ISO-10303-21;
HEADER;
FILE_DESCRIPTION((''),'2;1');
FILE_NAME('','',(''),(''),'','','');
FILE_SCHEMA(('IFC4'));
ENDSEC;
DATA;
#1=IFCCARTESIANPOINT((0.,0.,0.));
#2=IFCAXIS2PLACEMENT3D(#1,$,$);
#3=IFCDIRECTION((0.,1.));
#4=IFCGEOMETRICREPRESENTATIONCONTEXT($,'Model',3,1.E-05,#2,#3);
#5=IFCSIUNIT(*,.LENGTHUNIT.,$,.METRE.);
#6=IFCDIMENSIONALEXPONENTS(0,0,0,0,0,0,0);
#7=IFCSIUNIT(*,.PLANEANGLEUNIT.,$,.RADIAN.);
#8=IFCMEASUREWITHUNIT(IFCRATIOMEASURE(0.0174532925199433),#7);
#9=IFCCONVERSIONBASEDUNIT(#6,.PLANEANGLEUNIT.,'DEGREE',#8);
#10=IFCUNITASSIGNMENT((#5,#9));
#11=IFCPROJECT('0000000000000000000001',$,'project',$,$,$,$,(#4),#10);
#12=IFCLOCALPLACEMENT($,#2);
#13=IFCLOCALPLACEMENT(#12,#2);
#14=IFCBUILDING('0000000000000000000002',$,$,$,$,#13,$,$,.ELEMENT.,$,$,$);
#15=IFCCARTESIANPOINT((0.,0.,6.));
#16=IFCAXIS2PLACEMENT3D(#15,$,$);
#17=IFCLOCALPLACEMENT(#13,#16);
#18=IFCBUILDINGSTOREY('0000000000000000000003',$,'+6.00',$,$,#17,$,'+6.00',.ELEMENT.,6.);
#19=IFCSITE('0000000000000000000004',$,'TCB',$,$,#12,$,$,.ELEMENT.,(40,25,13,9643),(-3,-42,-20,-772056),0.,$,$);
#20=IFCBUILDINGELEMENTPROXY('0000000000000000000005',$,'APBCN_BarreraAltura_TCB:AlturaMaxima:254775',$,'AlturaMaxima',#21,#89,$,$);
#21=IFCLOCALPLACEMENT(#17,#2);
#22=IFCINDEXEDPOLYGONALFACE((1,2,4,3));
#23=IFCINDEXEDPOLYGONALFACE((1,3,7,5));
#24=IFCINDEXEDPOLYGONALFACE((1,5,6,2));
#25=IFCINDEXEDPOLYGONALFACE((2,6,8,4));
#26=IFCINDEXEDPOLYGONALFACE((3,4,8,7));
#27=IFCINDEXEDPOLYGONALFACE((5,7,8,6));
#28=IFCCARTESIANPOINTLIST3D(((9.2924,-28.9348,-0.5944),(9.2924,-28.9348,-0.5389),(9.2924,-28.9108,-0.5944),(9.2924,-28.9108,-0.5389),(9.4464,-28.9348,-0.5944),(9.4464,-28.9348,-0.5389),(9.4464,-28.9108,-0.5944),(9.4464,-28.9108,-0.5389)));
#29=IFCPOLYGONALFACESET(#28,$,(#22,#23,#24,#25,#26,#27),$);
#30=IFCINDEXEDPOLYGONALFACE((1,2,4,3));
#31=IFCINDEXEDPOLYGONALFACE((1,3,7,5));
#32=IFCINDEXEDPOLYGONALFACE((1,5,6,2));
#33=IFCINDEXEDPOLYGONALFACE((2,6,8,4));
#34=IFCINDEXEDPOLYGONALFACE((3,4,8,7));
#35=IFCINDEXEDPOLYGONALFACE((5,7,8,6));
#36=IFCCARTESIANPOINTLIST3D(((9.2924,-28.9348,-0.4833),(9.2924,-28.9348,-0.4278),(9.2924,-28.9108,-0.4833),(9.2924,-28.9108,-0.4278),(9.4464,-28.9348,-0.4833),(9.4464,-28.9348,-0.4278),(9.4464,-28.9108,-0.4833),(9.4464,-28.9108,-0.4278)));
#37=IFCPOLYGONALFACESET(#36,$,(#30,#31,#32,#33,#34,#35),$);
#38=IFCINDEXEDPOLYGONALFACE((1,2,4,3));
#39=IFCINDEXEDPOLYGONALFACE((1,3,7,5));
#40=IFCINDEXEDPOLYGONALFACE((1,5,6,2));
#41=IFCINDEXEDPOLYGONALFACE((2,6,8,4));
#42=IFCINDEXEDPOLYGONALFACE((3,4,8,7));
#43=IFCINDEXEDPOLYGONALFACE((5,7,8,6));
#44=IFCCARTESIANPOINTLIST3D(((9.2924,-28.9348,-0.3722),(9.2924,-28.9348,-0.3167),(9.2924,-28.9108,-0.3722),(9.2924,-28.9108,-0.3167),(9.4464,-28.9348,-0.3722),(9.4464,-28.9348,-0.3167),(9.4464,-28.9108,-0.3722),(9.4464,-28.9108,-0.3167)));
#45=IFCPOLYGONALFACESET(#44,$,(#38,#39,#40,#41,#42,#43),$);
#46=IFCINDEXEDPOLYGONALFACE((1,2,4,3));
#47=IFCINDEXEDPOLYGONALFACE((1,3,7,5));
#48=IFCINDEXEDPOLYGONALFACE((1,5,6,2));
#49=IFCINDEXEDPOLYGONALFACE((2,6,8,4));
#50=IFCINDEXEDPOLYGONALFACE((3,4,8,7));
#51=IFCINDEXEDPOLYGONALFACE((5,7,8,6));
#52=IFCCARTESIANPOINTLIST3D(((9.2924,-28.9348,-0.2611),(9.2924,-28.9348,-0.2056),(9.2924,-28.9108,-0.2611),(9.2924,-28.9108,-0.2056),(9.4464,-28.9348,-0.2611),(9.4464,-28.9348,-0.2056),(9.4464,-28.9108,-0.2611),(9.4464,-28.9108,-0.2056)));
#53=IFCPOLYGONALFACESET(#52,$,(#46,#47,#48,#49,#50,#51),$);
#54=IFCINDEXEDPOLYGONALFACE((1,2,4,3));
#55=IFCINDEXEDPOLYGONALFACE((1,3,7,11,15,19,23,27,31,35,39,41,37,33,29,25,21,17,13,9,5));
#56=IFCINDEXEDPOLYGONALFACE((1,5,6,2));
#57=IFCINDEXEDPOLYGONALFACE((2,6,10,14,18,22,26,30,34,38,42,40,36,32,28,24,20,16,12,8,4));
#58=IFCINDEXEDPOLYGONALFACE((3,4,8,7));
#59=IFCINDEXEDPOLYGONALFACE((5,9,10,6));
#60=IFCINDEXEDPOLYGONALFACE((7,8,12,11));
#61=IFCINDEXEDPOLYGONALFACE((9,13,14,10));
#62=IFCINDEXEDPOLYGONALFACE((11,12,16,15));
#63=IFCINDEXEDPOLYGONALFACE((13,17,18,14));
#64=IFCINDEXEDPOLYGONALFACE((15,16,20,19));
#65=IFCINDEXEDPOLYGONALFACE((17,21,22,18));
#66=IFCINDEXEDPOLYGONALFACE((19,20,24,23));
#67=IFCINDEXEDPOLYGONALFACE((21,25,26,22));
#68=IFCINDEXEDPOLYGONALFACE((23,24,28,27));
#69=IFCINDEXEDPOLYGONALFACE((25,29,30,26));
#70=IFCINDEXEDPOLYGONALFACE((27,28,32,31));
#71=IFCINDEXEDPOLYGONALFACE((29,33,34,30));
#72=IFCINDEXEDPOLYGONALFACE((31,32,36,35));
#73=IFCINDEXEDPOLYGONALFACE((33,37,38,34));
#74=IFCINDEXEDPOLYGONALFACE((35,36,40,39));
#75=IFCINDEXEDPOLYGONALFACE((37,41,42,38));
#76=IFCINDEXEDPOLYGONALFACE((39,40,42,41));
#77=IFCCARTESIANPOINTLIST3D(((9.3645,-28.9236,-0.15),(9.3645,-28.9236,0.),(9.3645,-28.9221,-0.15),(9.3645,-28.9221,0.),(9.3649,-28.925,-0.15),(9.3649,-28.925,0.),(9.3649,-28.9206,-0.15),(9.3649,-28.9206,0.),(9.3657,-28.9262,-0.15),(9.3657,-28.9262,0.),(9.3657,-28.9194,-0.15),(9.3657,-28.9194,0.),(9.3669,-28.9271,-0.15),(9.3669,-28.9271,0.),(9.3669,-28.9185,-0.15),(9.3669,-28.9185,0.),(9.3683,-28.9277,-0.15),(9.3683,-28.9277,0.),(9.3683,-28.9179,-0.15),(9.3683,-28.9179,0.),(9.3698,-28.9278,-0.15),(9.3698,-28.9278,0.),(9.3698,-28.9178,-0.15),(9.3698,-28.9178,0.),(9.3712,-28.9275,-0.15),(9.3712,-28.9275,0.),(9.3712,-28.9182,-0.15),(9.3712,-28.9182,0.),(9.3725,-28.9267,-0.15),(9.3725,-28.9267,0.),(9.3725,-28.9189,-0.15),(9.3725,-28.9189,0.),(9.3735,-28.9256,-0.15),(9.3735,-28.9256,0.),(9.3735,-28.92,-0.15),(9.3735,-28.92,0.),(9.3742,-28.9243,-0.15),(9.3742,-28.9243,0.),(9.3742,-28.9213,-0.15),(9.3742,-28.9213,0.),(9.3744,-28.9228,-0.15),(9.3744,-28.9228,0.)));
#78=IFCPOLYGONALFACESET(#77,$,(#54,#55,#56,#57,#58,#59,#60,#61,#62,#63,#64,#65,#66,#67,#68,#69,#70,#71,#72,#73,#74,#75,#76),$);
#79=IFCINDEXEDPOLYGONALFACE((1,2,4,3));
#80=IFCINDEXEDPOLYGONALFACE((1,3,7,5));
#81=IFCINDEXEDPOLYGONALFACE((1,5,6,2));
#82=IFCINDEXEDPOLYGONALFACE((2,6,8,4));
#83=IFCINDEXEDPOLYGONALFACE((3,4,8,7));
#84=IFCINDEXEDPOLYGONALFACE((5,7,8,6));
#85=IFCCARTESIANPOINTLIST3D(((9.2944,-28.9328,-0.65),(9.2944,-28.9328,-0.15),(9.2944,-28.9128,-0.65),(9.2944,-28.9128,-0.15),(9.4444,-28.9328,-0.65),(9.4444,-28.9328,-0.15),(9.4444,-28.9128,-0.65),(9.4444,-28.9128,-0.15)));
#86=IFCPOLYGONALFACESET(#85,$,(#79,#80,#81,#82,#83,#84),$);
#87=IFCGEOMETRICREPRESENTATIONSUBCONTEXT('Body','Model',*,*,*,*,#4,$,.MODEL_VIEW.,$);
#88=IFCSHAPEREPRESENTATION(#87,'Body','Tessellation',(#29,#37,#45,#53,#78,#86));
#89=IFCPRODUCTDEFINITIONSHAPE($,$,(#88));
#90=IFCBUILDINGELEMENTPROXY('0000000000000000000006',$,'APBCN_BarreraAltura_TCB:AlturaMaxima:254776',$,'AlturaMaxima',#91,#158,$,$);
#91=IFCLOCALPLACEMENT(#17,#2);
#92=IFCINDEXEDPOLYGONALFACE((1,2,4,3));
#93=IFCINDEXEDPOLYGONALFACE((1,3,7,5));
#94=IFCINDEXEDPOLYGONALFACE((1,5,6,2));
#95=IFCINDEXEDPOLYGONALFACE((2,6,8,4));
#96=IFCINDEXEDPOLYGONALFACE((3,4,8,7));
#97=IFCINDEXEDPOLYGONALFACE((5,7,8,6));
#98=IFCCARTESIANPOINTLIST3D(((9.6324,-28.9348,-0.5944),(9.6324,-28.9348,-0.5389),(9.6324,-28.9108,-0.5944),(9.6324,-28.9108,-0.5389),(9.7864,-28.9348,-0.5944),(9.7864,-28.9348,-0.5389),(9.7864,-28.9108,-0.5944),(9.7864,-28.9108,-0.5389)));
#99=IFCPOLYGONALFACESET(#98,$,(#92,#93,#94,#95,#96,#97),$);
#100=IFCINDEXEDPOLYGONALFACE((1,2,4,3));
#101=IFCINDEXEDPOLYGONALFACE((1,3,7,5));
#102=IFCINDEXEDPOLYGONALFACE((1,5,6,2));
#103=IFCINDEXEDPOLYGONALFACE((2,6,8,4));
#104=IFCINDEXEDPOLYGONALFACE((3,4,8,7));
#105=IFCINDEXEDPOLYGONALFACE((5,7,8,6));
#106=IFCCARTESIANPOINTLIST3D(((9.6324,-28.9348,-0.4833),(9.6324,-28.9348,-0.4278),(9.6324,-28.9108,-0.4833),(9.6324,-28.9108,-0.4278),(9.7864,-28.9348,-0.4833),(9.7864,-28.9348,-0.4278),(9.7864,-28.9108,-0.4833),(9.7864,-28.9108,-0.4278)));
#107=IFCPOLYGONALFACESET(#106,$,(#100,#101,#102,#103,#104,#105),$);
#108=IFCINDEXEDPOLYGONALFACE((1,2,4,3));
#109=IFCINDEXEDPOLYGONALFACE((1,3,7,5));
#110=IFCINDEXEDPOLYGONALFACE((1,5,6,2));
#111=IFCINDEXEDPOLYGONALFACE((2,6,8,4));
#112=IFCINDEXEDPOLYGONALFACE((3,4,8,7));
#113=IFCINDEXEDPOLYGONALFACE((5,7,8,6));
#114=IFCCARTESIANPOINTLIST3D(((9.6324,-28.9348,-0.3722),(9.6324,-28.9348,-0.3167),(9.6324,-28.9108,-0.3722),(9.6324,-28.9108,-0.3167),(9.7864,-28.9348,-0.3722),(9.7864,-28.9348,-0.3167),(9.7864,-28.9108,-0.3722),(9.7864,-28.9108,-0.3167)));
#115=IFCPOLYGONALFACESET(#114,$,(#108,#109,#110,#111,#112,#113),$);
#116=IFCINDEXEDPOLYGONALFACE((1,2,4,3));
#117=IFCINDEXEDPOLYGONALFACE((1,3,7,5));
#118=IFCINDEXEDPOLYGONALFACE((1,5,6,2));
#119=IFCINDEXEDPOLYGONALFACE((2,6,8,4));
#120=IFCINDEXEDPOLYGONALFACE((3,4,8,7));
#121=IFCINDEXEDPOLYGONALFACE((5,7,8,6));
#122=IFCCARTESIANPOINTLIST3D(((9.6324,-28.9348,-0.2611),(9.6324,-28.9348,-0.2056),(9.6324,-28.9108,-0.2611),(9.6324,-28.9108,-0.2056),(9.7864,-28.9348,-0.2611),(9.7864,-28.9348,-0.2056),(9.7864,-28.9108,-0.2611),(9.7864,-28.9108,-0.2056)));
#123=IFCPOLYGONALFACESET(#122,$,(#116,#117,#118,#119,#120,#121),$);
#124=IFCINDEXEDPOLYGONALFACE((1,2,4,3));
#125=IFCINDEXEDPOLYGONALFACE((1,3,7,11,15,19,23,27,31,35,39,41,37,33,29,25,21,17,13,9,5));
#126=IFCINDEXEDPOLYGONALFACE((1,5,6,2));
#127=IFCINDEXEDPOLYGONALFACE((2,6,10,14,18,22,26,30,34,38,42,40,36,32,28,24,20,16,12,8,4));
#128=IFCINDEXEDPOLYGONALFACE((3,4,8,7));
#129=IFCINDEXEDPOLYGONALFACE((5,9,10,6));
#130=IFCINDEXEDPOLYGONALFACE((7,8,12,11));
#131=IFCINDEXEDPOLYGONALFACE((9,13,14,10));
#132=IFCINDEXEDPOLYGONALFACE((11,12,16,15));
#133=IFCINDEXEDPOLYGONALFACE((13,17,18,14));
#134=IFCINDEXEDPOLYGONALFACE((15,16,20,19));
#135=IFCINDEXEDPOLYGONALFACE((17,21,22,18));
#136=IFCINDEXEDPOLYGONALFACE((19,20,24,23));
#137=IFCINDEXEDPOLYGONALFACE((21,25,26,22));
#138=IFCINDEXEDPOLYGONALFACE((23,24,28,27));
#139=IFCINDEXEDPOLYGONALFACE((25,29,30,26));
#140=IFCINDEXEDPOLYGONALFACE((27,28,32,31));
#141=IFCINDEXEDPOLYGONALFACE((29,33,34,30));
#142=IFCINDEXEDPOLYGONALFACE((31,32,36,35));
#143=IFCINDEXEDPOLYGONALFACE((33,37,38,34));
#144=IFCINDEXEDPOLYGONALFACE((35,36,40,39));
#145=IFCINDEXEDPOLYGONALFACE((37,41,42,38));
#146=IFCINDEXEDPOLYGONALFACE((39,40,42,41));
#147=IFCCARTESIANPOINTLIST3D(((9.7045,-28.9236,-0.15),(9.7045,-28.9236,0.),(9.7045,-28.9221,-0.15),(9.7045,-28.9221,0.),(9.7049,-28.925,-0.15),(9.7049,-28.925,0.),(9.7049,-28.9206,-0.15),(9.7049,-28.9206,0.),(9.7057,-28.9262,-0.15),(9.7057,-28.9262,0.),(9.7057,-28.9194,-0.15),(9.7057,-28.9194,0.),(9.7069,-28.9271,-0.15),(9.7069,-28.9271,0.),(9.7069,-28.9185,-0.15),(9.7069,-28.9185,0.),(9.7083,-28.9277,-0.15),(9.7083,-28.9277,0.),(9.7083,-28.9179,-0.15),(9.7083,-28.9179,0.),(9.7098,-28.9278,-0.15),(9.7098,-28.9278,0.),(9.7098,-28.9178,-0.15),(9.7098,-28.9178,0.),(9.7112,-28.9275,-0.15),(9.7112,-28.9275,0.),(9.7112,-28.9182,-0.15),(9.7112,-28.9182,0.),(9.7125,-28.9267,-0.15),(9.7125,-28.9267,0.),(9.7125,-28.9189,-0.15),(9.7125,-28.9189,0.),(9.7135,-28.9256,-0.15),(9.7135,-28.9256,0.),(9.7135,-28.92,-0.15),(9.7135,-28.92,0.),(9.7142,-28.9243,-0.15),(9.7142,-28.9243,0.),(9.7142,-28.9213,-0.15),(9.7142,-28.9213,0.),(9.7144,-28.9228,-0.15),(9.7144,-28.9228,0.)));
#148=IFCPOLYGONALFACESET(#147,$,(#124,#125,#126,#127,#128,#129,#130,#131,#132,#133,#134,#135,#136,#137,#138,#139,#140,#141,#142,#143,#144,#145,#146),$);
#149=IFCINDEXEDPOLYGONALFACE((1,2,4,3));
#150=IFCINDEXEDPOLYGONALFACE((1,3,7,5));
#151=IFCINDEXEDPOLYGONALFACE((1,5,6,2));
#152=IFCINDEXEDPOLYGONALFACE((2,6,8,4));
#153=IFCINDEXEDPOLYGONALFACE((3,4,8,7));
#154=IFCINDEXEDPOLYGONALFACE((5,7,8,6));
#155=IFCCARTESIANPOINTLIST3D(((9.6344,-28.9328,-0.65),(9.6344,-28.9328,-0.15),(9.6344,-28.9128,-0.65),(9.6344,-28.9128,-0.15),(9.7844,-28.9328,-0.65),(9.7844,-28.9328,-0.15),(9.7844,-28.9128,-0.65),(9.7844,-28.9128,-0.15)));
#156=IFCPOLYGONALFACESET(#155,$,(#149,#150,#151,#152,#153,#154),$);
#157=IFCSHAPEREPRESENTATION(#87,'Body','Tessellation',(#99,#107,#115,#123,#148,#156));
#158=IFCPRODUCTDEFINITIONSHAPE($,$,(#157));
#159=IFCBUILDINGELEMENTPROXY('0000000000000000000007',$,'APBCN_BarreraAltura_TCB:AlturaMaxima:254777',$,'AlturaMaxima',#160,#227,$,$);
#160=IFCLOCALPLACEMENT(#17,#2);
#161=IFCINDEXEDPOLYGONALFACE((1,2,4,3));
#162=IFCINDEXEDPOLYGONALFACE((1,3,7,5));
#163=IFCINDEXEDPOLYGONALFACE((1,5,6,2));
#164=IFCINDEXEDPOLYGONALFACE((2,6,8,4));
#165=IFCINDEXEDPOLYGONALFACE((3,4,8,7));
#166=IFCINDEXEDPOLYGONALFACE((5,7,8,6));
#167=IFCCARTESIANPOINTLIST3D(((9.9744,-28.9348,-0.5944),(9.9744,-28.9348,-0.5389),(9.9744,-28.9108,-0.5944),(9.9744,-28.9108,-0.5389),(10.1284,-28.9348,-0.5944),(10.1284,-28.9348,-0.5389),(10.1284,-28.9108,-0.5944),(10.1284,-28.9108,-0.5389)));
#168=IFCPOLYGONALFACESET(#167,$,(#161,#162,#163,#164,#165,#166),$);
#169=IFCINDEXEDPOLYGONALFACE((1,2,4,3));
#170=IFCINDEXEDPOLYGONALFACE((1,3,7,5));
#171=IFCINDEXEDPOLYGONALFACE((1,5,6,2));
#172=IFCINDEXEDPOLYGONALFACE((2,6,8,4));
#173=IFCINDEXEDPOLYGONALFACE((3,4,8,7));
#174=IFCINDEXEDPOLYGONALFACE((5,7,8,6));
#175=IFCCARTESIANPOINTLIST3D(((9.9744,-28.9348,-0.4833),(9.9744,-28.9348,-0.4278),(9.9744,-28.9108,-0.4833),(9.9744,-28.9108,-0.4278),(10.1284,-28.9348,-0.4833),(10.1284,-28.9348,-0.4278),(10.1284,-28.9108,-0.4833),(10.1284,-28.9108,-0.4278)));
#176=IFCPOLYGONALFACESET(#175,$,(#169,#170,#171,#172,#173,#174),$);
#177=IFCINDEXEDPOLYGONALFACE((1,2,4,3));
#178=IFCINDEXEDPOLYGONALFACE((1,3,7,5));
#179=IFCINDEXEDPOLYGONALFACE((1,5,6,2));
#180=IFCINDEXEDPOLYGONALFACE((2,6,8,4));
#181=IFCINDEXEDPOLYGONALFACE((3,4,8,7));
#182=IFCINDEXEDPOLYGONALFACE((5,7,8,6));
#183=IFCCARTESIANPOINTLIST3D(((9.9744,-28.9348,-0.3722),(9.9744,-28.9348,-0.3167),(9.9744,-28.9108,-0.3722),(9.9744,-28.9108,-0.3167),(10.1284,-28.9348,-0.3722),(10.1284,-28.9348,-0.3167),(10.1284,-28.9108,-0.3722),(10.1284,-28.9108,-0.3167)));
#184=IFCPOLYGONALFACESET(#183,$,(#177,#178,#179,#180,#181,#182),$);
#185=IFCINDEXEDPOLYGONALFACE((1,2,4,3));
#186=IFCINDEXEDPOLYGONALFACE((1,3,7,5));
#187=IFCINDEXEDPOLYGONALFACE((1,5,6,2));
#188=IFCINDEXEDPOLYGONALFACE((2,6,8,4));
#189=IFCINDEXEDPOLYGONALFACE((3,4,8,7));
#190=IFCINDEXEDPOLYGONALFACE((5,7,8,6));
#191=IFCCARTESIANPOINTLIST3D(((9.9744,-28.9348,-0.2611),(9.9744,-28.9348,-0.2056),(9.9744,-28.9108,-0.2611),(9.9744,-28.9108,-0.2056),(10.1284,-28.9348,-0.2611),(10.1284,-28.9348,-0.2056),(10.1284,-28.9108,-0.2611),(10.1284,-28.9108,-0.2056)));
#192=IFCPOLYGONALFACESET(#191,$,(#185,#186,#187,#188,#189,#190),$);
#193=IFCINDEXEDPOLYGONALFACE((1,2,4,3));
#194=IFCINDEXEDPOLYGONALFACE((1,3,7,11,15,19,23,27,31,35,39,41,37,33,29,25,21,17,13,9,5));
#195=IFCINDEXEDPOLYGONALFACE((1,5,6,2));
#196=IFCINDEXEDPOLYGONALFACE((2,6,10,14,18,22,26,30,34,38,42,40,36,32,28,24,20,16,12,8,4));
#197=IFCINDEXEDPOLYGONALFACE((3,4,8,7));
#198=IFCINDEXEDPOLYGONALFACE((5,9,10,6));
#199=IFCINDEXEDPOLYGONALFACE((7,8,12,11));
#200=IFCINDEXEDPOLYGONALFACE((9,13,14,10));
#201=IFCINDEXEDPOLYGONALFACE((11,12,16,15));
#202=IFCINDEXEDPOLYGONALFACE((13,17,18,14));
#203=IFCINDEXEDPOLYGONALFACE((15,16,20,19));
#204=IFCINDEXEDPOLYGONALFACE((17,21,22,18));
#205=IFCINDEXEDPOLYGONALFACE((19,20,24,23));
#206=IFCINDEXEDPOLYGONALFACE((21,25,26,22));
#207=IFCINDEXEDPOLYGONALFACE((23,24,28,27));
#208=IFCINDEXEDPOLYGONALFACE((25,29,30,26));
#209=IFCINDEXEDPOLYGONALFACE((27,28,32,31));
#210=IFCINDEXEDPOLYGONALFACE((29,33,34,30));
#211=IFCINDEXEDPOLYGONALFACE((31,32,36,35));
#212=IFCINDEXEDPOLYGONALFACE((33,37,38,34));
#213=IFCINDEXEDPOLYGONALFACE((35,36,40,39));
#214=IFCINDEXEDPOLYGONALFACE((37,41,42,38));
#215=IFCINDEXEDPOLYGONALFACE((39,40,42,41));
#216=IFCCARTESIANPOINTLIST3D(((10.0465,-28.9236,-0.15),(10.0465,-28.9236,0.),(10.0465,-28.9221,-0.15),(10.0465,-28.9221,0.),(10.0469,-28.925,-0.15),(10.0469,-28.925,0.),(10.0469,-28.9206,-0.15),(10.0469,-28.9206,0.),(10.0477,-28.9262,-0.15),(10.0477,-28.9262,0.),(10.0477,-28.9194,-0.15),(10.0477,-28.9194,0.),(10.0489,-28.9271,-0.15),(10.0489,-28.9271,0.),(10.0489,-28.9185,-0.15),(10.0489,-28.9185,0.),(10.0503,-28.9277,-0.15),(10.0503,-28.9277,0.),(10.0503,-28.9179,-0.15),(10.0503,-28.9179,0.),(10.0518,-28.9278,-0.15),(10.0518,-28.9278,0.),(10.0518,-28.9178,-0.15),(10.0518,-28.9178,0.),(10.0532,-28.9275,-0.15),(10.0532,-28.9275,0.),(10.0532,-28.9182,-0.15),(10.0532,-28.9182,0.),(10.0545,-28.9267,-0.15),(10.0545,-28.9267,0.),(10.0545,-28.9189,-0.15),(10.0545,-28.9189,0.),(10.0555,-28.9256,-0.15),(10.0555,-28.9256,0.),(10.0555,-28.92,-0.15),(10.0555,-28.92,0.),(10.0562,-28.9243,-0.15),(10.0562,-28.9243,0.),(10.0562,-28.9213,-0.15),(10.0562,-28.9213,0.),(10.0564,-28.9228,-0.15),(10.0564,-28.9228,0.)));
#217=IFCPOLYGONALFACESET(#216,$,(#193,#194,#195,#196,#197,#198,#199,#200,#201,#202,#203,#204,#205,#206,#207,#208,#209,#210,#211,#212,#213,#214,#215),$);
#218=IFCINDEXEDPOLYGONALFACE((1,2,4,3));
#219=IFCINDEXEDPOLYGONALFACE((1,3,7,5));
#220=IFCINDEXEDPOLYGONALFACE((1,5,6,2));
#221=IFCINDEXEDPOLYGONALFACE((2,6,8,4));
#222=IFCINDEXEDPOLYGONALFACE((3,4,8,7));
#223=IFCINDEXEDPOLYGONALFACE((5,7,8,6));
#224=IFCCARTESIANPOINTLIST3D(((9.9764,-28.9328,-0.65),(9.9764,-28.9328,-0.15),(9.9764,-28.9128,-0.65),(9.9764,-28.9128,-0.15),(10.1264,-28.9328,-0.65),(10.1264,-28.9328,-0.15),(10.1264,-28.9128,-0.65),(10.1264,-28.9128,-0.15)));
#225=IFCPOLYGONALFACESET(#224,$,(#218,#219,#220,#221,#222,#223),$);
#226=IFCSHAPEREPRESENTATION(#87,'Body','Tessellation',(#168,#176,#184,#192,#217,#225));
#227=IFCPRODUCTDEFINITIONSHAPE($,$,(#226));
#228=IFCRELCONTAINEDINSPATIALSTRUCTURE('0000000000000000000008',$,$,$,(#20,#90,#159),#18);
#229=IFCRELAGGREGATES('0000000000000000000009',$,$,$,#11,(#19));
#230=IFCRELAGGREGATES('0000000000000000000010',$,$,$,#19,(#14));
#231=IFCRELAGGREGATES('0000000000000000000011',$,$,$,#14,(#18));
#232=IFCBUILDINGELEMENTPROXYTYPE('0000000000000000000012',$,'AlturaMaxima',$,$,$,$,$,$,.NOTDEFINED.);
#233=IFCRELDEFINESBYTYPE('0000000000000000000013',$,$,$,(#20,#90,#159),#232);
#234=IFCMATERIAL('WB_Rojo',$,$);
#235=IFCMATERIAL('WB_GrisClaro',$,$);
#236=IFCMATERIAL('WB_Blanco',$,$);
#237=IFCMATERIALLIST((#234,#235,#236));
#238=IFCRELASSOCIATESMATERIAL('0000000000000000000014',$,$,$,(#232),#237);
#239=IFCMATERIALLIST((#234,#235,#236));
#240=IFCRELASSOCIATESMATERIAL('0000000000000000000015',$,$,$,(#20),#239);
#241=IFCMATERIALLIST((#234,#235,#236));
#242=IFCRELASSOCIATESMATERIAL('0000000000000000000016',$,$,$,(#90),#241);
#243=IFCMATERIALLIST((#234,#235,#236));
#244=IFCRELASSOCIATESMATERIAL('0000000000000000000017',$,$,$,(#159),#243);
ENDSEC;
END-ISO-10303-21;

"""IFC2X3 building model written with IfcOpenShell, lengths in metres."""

from ifc_helpers import new_model, entity, si_unit, converted_unit, direction, frame, frame_2d, origin, origin_2d_with_axis, place, context, subcontext, project, spatial, rectangle, circle, extrude, source, transform, mapped, material, material_list, type_object, type_shapes, element, save


model = new_model("IFC2X3")

# Units and contexts
model_context = context("Model", 3, precision=1e-05, world=origin(), true_north=direction((0.0, 1.0)))
body_context = subcontext(model_context, "Body", "Model", "MODEL_VIEW")
ifc_project = project(units=[si_unit("LENGTHUNIT", "METRE"), converted_unit("PLANEANGLEUNIT", "DEGREE", entity("IfcRatioMeasure", 0.0174532925199433), si_unit("PLANEANGLEUNIT", "RADIAN"), dimensions=[0, 0, 0, 0, 0, 0, 0])], contexts=[model_context])

# Site, building, storey
site_placement = place(None, origin())
site = spatial("IfcSite", under=ifc_project, at=site_placement, Name="TCB", CompositionType="ELEMENT", RefLatitude=(40, 25, 13, 9643), RefLongitude=(-3, -42, -20, -772056), RefElevation=0.0)
building_placement = place(site_placement, origin())
building = spatial("IfcBuilding", under=site, at=building_placement, CompositionType="ELEMENT")
storey_placement = place(building_placement, frame((0.0, 0.0, 6.0)))
storey = spatial("IfcBuildingStorey", under=building, at=storey_placement, Name="+6.00", LongName="+6.00", CompositionType="ELEMENT", Elevation=6.0)

# Building element proxies
ifc_material_1 = material(Name="WB_Rojo")
ifc_material_2 = material(Name="WB_GrisClaro")
ifc_material_3 = material(Name="WB_Blanco")
ifc_material_list_1 = material_list([ifc_material_1, ifc_material_2, ifc_material_3])
building_element_proxy_type = type_object("IfcBuildingElementProxyType", Name="AlturaMaxima", PredefinedType="NOTDEFINED", material=ifc_material_list_1)
shared_shape = source(origin(), body_context, "Body", "SweptSolid", [
    extrude(rectangle(XDim=0.154, YDim=0.024, at=frame_2d((0.0, 0.0), x_axis=(1.0, 0.0))), frame((0.0, 0.0, -0.5944), z_axis=(0.0, 0.0, 1.0), x_axis=(-1.0, 0.0, 0.0)), (0.0, 0.0, 1.0), 0.0556),
    extrude(rectangle(XDim=0.154, YDim=0.024, at=frame_2d((0.0, 0.0), x_axis=(1.0, 0.0))), frame((0.0, 0.0, -0.4833), z_axis=(0.0, 0.0, 1.0), x_axis=(-1.0, 0.0, 0.0)), (0.0, 0.0, 1.0), 0.0556),
    extrude(rectangle(XDim=0.154, YDim=0.024, at=frame_2d((0.0, 0.0), x_axis=(1.0, 0.0))), frame((0.0, 0.0, -0.3722), z_axis=(0.0, 0.0, 1.0), x_axis=(-1.0, 0.0, 0.0)), (0.0, 0.0, 1.0), 0.0556),
    extrude(rectangle(XDim=0.154, YDim=0.024, at=frame_2d((0.0, 0.0), x_axis=(1.0, 0.0))), frame((0.0, 0.0, -0.2611), z_axis=(0.0, 0.0, 1.0), x_axis=(-1.0, 0.0, 0.0)), (0.0, 0.0, 1.0), 0.0556),
    extrude(circle(Radius=0.005, at=frame_2d((0.0, 0.0), x_axis=(1.0, 0.0))), frame((0.0, 0.0, -0.15)), (0.0, 0.0, 1.0), 0.15),
    extrude(rectangle(XDim=0.02, YDim=0.15, at=origin_2d_with_axis()), frame((0.0, 0.0, -0.65), z_axis=(0.0, 0.0, 1.0), x_axis=(0.0, 1.0, 0.0)), (0.0, 0.0, 1.0), 0.5),
])
type_shapes(building_element_proxy_type, [shared_shape])
ifc_material_list_2 = material_list([ifc_material_1, ifc_material_2, ifc_material_3])
proxy_1_placement = place(storey_placement, frame((9.3694, -28.9228, 0.0)))
element("IfcBuildingElementProxy", 1, at=proxy_1_placement, inside=storey, type_object=building_element_proxy_type, material=ifc_material_list_2, Name="APBCN_BarreraAltura_TCB:AlturaMaxima:254775", ObjectType="AlturaMaxima", context=body_context, shape_type="MappedRepresentation", body=[
    mapped(shared_shape, transform((0.0, 0.0, 0.0), scale=1.0)),
])
ifc_material_list_3 = material_list([ifc_material_1, ifc_material_2, ifc_material_3])
proxy_2_placement = place(storey_placement, frame((9.7094, -28.9228, 0.0)))
element("IfcBuildingElementProxy", 2, at=proxy_2_placement, inside=storey, type_object=building_element_proxy_type, material=ifc_material_list_3, Name="APBCN_BarreraAltura_TCB:AlturaMaxima:254776", ObjectType="AlturaMaxima", context=body_context, shape_type="MappedRepresentation", body=[
    mapped(shared_shape, transform((0.0, 0.0, 0.0), scale=1.0)),
])
ifc_material_list_4 = material_list([ifc_material_1, ifc_material_2, ifc_material_3])
proxy_3_placement = place(storey_placement, frame((10.0514, -28.9228, 0.0)))
element("IfcBuildingElementProxy", 3, at=proxy_3_placement, inside=storey, type_object=building_element_proxy_type, material=ifc_material_list_4, Name="APBCN_BarreraAltura_TCB:AlturaMaxima:254777", ObjectType="AlturaMaxima", context=body_context, shape_type="MappedRepresentation", body=[
    mapped(shared_shape, transform((0.0, 0.0, 0.0), scale=1.0)),
])

save(model, "model.ifc")
